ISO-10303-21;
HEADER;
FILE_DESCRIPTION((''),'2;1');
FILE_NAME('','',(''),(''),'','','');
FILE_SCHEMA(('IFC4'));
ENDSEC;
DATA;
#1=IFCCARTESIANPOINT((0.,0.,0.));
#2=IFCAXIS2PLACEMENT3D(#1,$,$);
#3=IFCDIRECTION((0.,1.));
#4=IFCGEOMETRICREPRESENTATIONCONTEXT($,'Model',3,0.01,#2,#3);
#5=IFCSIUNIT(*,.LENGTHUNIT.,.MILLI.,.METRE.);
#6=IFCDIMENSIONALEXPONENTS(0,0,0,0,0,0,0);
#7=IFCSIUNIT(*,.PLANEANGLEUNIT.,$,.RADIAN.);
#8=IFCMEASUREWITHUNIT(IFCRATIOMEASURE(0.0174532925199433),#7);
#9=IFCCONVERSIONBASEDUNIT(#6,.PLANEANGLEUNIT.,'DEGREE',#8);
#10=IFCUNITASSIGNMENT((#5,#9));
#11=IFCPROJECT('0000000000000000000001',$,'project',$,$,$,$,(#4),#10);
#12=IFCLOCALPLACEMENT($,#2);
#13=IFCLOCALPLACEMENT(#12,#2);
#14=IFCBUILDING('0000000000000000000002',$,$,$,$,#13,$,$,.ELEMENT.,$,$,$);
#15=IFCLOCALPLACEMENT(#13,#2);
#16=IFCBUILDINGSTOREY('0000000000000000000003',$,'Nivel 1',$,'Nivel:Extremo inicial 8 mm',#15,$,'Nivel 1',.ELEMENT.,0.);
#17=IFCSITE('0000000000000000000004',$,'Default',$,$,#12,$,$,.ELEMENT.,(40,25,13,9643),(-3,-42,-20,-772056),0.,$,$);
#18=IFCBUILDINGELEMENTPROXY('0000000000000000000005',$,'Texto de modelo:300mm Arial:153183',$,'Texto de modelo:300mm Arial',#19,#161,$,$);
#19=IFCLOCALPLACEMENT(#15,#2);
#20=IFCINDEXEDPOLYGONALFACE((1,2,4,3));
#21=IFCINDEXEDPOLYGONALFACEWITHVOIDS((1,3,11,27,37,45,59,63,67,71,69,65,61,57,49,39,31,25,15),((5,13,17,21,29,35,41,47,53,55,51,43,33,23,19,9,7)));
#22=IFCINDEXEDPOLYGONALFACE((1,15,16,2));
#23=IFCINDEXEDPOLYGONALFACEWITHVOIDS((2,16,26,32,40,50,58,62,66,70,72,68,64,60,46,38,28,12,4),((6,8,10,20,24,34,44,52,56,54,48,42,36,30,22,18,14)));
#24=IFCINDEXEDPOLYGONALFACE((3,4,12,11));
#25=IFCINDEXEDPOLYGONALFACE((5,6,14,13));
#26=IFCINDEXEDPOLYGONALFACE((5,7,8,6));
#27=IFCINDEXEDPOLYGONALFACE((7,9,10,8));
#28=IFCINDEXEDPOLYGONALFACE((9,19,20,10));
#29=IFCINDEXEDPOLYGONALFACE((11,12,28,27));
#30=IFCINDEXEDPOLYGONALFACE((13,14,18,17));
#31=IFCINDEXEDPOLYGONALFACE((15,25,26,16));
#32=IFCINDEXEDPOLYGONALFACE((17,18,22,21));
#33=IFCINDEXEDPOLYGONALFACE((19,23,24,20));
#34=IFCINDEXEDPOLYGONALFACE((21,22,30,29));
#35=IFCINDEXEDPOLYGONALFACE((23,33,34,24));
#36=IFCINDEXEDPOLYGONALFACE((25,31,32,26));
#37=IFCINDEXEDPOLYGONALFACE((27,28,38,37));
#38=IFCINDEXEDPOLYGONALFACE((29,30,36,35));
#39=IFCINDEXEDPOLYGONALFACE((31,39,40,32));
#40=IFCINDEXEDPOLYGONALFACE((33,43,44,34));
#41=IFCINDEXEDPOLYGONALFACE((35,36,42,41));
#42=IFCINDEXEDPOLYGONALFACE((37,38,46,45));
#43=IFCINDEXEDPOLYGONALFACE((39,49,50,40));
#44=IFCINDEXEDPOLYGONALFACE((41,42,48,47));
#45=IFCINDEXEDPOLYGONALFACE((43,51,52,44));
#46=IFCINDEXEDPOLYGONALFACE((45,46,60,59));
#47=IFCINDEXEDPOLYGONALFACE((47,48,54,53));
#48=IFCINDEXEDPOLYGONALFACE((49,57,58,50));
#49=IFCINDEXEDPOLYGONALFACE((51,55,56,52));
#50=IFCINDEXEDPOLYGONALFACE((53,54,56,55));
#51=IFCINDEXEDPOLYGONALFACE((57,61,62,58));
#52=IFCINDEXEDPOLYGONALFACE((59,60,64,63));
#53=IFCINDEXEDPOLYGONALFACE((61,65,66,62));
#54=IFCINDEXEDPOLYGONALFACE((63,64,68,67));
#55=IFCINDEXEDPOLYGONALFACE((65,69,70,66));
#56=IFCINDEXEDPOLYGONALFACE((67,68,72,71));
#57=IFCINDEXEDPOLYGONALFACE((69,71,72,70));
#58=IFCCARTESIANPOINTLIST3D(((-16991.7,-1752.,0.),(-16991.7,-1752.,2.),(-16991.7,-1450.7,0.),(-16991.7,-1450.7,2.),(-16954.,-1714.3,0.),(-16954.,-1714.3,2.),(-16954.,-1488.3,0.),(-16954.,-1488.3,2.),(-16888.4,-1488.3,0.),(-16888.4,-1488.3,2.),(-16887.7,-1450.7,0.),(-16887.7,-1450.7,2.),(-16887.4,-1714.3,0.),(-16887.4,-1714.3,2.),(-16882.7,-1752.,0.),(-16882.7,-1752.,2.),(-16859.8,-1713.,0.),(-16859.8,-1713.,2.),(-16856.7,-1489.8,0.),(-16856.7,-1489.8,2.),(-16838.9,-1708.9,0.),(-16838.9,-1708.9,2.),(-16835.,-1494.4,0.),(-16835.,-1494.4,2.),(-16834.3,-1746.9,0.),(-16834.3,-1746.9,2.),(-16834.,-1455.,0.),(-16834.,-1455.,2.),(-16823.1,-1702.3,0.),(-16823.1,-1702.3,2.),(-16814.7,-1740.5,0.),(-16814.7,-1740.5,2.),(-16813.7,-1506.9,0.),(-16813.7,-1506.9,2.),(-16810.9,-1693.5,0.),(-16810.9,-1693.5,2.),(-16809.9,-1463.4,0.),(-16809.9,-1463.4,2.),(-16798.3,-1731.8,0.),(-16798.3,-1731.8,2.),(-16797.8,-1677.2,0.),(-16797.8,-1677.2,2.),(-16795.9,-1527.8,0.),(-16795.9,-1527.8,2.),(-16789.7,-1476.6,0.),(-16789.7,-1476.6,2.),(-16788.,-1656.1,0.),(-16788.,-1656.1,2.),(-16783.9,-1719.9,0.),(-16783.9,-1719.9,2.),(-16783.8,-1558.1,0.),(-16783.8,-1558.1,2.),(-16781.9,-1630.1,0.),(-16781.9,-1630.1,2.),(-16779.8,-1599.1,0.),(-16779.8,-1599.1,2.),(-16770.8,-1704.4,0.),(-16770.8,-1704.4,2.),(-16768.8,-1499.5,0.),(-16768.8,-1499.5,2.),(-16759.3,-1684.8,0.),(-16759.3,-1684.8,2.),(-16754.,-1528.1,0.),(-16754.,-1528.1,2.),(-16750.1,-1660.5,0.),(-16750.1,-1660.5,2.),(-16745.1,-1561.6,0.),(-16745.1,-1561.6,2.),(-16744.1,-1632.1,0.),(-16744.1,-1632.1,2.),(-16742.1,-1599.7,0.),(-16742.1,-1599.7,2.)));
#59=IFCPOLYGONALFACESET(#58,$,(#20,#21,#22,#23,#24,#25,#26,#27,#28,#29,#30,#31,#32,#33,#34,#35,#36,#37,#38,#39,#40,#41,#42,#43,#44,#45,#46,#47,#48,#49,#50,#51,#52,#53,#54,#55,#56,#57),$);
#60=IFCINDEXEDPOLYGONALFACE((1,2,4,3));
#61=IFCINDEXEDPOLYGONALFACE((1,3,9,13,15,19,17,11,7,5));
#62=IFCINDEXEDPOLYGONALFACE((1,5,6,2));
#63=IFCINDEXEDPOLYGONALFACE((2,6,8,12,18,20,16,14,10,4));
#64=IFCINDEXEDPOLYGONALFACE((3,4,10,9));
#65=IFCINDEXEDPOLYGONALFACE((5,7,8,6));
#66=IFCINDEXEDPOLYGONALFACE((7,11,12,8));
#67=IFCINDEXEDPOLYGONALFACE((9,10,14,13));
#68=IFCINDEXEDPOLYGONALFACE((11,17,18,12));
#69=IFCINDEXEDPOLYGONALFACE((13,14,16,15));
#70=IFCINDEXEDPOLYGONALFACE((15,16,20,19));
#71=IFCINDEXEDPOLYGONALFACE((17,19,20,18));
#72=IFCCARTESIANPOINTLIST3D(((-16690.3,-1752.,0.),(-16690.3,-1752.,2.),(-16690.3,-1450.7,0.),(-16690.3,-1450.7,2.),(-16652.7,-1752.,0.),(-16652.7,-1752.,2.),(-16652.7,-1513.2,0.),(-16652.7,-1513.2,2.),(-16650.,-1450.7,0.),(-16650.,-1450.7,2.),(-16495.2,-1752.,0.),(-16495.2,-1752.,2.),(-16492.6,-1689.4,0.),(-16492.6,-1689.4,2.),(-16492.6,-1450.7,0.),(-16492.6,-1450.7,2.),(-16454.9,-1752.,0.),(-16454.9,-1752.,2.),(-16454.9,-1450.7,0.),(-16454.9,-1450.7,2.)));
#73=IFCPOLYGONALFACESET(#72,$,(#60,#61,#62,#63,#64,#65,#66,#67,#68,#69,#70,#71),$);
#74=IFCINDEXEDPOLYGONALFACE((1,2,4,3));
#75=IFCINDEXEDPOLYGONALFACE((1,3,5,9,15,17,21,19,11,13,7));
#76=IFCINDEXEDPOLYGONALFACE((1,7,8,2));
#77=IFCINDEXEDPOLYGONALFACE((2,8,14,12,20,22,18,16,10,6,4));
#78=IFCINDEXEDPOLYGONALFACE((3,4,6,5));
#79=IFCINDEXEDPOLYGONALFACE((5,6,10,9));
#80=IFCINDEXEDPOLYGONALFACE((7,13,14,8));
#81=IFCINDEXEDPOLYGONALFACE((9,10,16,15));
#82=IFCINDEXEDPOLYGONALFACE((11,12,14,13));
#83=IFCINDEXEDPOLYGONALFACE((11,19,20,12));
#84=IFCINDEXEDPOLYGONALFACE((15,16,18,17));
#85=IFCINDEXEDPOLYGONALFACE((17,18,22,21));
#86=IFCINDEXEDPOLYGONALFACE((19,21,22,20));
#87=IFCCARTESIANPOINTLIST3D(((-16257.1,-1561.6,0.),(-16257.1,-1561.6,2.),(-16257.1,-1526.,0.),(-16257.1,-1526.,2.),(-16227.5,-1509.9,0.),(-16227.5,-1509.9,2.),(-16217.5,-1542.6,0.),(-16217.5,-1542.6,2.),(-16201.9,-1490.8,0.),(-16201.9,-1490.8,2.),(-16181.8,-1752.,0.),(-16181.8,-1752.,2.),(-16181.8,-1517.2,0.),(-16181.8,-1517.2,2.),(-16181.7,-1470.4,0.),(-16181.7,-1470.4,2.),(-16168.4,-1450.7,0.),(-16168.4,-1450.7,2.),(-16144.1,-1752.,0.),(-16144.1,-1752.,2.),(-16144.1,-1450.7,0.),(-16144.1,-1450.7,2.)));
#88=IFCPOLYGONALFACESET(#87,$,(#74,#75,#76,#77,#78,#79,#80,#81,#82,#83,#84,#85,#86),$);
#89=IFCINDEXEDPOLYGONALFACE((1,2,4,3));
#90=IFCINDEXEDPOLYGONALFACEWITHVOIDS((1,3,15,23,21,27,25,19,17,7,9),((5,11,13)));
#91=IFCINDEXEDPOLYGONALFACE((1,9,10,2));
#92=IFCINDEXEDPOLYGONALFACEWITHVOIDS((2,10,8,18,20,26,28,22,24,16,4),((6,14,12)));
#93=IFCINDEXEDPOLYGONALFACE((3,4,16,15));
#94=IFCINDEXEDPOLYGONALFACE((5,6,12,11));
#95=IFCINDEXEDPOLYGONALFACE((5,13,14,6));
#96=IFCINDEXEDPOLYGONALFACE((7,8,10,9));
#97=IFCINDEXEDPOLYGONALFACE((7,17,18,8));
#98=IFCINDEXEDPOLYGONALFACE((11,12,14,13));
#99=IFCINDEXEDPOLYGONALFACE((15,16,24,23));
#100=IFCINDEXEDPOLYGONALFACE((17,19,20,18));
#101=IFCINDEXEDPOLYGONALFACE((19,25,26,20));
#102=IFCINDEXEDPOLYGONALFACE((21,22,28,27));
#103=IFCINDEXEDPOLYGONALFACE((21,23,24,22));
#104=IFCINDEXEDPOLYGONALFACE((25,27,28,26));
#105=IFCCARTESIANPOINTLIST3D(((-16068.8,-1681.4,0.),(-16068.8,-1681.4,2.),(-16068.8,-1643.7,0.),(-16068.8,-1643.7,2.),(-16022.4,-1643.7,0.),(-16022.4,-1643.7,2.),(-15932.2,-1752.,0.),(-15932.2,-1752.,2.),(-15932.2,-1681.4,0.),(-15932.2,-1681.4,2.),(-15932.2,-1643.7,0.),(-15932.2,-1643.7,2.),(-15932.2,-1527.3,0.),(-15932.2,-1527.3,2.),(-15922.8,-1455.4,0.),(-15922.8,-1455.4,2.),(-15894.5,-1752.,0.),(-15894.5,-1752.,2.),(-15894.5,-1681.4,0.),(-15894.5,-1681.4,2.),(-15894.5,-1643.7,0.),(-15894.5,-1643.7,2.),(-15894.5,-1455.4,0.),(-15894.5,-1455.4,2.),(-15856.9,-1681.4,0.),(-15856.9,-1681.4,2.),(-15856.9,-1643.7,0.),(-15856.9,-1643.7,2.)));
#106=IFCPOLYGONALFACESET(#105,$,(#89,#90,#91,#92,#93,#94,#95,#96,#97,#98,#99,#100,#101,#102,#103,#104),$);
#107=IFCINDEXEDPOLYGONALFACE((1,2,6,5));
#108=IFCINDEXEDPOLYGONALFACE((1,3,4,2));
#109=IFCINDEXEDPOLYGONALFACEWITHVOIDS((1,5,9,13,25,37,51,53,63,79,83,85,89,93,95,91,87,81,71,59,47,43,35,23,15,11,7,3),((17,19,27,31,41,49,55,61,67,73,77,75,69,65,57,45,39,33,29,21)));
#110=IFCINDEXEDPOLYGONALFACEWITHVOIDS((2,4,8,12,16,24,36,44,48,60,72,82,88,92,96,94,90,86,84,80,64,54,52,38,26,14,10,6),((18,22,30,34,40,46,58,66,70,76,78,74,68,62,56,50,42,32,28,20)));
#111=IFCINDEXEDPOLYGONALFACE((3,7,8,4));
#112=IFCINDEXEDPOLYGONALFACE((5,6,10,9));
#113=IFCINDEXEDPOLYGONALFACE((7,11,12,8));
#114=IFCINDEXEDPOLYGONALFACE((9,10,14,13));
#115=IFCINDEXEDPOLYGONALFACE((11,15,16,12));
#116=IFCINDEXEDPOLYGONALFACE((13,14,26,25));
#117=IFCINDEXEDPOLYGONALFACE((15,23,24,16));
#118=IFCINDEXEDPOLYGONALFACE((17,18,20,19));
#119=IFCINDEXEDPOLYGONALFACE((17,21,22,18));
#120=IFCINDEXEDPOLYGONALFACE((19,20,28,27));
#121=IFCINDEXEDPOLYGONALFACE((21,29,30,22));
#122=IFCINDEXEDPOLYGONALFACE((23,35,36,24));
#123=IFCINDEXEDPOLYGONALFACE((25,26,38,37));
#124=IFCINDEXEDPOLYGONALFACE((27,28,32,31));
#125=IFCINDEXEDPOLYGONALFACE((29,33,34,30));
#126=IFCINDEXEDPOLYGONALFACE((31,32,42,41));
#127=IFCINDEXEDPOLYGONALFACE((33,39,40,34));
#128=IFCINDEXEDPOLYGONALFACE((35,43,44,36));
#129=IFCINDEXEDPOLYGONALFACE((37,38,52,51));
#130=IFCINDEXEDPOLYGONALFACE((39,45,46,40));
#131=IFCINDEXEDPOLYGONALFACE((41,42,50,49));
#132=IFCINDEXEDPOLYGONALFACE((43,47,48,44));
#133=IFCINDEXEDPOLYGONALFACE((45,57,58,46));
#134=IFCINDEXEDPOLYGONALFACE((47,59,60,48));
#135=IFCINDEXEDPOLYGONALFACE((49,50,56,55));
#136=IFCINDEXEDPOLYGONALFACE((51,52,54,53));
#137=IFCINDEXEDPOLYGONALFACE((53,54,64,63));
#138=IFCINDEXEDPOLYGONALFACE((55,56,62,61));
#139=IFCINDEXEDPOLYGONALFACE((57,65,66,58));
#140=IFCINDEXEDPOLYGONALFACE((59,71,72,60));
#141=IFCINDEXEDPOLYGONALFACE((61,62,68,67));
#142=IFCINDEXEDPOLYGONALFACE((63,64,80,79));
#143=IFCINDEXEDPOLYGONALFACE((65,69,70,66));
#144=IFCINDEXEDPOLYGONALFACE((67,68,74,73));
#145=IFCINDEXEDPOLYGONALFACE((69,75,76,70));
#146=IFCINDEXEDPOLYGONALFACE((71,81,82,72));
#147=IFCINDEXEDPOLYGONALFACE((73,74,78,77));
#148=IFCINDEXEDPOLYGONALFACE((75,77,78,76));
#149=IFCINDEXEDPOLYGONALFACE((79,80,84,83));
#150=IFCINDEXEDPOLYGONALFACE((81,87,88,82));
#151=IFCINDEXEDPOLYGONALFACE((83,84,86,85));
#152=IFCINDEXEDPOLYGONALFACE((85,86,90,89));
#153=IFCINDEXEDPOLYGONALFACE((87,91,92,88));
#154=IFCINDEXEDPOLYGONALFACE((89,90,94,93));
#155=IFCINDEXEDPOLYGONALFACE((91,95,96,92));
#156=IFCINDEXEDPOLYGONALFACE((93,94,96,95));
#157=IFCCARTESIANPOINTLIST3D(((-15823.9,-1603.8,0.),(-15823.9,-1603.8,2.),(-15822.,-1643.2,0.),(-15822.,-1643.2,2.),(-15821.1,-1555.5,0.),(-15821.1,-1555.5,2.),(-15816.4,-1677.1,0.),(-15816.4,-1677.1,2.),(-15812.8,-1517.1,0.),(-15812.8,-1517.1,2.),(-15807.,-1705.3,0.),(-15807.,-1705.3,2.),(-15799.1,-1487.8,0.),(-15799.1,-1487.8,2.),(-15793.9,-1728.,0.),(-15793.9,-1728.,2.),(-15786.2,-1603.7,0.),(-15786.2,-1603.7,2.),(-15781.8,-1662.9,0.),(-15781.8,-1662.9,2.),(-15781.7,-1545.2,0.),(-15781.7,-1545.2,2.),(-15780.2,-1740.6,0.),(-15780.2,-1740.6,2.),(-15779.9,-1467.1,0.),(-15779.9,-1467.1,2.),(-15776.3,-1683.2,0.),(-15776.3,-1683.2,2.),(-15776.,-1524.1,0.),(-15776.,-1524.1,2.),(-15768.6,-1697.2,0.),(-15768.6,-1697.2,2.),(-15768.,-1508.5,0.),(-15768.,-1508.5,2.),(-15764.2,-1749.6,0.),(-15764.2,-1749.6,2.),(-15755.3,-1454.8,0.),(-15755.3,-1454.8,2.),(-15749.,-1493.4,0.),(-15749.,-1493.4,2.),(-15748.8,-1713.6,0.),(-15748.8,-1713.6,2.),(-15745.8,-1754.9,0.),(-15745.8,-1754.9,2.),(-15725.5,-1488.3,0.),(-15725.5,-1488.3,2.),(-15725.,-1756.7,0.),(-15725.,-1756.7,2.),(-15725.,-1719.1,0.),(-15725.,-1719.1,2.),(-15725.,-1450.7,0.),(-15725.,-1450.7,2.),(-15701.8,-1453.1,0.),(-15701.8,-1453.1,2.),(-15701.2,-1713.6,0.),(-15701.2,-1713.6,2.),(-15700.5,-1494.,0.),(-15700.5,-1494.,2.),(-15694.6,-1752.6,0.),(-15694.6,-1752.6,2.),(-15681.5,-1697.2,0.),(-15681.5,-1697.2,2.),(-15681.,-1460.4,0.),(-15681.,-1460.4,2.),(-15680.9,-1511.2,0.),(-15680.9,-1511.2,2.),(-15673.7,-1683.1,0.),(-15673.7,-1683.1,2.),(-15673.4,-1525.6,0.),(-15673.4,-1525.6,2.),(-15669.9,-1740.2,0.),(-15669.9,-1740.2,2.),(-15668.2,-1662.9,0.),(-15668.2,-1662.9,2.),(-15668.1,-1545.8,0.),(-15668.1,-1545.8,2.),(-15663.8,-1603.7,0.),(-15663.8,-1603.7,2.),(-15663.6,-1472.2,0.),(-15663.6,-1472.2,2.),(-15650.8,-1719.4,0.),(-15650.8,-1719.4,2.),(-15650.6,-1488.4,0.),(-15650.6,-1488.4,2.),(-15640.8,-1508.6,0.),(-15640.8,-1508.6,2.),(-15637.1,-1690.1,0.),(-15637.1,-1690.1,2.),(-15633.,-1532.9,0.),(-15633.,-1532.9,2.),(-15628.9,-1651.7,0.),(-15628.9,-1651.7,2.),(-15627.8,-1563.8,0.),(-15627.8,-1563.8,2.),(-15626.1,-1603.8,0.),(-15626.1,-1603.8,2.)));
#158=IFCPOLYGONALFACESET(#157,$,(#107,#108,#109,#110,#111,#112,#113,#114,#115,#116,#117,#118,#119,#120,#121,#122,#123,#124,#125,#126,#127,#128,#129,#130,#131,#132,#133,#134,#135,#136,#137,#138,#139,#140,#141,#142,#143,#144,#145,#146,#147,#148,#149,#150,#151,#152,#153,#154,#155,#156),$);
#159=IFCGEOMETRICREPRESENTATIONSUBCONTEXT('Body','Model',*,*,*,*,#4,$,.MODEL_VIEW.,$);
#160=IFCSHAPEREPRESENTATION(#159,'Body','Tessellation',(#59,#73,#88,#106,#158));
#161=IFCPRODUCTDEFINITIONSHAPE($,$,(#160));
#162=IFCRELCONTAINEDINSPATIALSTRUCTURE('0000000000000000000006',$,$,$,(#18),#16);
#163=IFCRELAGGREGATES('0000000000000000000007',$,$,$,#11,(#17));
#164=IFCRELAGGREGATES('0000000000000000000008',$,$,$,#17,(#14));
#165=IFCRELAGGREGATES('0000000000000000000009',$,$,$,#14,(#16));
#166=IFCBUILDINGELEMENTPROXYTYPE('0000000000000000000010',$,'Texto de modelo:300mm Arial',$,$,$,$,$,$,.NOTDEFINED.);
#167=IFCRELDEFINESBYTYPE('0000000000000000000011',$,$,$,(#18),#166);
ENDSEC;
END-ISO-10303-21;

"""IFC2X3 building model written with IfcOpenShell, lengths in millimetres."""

from ifc_helpers import new_model, entity, si_unit, converted_unit, direction, frame, origin, place, context, subcontext, project, spatial, polyline, outline, extrude, type_object, element, save


model = new_model("IFC2X3")

# Units and contexts
model_context = context("Model", 3, precision=0.01, world=origin(), true_north=direction((0.0, 1.0)))
body_context = subcontext(model_context, "Body", "Model", "MODEL_VIEW")
ifc_project = project(units=[si_unit("LENGTHUNIT", "METRE", prefix="MILLI"), converted_unit("PLANEANGLEUNIT", "DEGREE", entity("IfcRatioMeasure", 0.0174532925199433), si_unit("PLANEANGLEUNIT", "RADIAN"), dimensions=[0, 0, 0, 0, 0, 0, 0])], contexts=[model_context])

# Site, building, storey
site_placement = place(None, origin())
site = spatial("IfcSite", under=ifc_project, at=site_placement, Name="Default", CompositionType="ELEMENT", RefLatitude=(40, 25, 13, 9643), RefLongitude=(-3, -42, -20, -772056), RefElevation=0.0)
building_placement = place(site_placement, origin())
building = spatial("IfcBuilding", under=site, at=building_placement, CompositionType="ELEMENT")
storey_placement = place(building_placement, origin())
storey = spatial("IfcBuildingStorey", under=building, at=storey_placement, Name="Nivel 1", ObjectType="Nivel:Extremo inicial 8 mm", LongName="Nivel 1", CompositionType="ELEMENT", Elevation=0.0)

# Building element proxy
building_element_proxy_type_1 = type_object("IfcBuildingElementProxyType", Name="Texto de modelo:300mm Arial", PredefinedType="NOTDEFINED")
proxy_1_placement = place(storey_placement, frame((-16991.7, -1756.7, 0.0)))
element("IfcBuildingElementProxy", 1, at=proxy_1_placement, inside=storey, type_object=building_element_proxy_type_1, Name="Texto de modelo:300mm Arial:153183", ObjectType="Texto de modelo:300mm Arial", context=body_context, shape_type="SweptSolid", body=[
    extrude(outline(polyline([(-178.4, -141.0), (-69.4, -141.0), (-21.0, -135.8), (-1.4, -129.5), (15.0, -120.7), (29.4, -108.9), (42.6, -93.4), (54.0, -73.7), (63.2, -49.5), (69.2, -21.0), (71.2, 11.3), (68.2, 49.4), (59.3, 83.0), (44.5, 111.5), (23.7, 134.5), (3.4, 147.7), (-20.6, 156.1), (-74.4, 160.4), (-178.4, 160.4), (-178.4, -141.0)]), holes=[polyline([(-140.7, -103.3), (-140.7, 122.7), (-75.1, 122.7), (-43.3, 121.2), (-21.7, 116.7), (-0.4, 104.1), (17.4, 83.3), (29.5, 53.0), (33.5, 11.9), (31.5, -19.1), (25.3, -45.1), (15.5, -66.2), (2.4, -82.5), (-9.8, -91.3), (-25.6, -97.9), (-46.5, -101.9), (-74.1, -103.3), (-140.7, -103.3)])]), frame((178.4, 145.7, 0.0)), (0.0, 0.0, 1.0), 2.0),
    extrude(outline(polyline([(-117.7, -150.7), (-80.1, -150.7), (-80.1, 88.1), (77.4, -150.7), (117.7, -150.7), (117.7, 150.7), (80.1, 150.7), (80.1, -88.1), (-77.4, 150.7), (-117.7, 150.7), (-117.7, -150.7)])), frame((419.1, 155.4, 0.0)), (0.0, 0.0, 1.0), 2.0),
    extrude(outline(polyline([(-204.4, -52.5), (97.0, -52.5), (97.0, -28.2), (77.2, -14.9), (56.9, 5.3), (37.7, 30.9), (21.6, 60.5), (-14.0, 60.5), (5.0, 20.8), (30.4, -14.9), (-204.4, -14.9), (-204.4, -52.5)])), frame((795.1, 209.1, 0.0), z_axis=(0.0, 0.0, 1.0), x_axis=(0.0, 1.0, 0.0)), (0.0, 0.0, 1.0), 2.0),
    extrude(outline(polyline([(-3.4, -109.2), (34.2, -109.2), (34.2, -38.5), (71.9, -38.5), (71.9, -0.9), (34.2, -0.9), (34.2, 187.5), (6.0, 187.5), (-140.0, -0.9), (-140.0, -38.5), (-3.4, -38.5), (-3.4, -109.2)]), holes=[polyline([(-3.4, -0.9), (-93.6, -0.9), (-3.4, 115.5), (-3.4, -0.9)])]), frame((1062.9, 113.9, 0.0)), (0.0, 0.0, 1.0), 2.0),
    extrude(outline(polyline([(-5.6, -99.5), (33.9, -99.5), (68.0, -95.5), (96.7, -87.5), (120.0, -75.5), (133.2, -62.4), (142.9, -46.8), (149.1, -28.7), (151.9, -8.0), (149.2, 22.6), (138.0, 47.8), (118.2, 67.9), (89.5, 82.9), (51.6, 93.0), (3.8, 98.0), (-36.2, 98.2), (-67.3, 94.5), (-91.9, 87.9), (-112.6, 79.0), (-129.4, 66.8), (-142.0, 50.0), (-150.3, 29.6), (-153.8, 6.5), (-151.2, -23.9), (-140.1, -49.1), (-120.3, -69.2), (-91.7, -84.4), (-53.6, -94.5), (-5.6, -99.5)]), holes=[polyline([(-3.9, -61.9), (-62.1, -54.6), (-82.9, -47.9), (-98.1, -39.2), (-112.3, -19.5), (-116.2, 4.3), (-109.3, 28.9), (-91.2, 47.7), (-76.5, 54.5), (-56.1, 58.9), (1.9, 60.4), (60.8, 53.2), (80.8, 46.7), (94.5, 38.3), (109.9, 17.8), (114.3, -6.3), (107.7, -29.8), (90.4, -48.7), (76.0, -55.8), (55.5, -60.3), (-3.9, -61.9)])]), frame((1267.5, 152.1, 0.0), z_axis=(0.0, 0.0, 1.0), x_axis=(0.047515, -0.998871, 0.0)), (0.0, 0.0, 1.0), 2.0),
])

save(model, "model.ifc")
